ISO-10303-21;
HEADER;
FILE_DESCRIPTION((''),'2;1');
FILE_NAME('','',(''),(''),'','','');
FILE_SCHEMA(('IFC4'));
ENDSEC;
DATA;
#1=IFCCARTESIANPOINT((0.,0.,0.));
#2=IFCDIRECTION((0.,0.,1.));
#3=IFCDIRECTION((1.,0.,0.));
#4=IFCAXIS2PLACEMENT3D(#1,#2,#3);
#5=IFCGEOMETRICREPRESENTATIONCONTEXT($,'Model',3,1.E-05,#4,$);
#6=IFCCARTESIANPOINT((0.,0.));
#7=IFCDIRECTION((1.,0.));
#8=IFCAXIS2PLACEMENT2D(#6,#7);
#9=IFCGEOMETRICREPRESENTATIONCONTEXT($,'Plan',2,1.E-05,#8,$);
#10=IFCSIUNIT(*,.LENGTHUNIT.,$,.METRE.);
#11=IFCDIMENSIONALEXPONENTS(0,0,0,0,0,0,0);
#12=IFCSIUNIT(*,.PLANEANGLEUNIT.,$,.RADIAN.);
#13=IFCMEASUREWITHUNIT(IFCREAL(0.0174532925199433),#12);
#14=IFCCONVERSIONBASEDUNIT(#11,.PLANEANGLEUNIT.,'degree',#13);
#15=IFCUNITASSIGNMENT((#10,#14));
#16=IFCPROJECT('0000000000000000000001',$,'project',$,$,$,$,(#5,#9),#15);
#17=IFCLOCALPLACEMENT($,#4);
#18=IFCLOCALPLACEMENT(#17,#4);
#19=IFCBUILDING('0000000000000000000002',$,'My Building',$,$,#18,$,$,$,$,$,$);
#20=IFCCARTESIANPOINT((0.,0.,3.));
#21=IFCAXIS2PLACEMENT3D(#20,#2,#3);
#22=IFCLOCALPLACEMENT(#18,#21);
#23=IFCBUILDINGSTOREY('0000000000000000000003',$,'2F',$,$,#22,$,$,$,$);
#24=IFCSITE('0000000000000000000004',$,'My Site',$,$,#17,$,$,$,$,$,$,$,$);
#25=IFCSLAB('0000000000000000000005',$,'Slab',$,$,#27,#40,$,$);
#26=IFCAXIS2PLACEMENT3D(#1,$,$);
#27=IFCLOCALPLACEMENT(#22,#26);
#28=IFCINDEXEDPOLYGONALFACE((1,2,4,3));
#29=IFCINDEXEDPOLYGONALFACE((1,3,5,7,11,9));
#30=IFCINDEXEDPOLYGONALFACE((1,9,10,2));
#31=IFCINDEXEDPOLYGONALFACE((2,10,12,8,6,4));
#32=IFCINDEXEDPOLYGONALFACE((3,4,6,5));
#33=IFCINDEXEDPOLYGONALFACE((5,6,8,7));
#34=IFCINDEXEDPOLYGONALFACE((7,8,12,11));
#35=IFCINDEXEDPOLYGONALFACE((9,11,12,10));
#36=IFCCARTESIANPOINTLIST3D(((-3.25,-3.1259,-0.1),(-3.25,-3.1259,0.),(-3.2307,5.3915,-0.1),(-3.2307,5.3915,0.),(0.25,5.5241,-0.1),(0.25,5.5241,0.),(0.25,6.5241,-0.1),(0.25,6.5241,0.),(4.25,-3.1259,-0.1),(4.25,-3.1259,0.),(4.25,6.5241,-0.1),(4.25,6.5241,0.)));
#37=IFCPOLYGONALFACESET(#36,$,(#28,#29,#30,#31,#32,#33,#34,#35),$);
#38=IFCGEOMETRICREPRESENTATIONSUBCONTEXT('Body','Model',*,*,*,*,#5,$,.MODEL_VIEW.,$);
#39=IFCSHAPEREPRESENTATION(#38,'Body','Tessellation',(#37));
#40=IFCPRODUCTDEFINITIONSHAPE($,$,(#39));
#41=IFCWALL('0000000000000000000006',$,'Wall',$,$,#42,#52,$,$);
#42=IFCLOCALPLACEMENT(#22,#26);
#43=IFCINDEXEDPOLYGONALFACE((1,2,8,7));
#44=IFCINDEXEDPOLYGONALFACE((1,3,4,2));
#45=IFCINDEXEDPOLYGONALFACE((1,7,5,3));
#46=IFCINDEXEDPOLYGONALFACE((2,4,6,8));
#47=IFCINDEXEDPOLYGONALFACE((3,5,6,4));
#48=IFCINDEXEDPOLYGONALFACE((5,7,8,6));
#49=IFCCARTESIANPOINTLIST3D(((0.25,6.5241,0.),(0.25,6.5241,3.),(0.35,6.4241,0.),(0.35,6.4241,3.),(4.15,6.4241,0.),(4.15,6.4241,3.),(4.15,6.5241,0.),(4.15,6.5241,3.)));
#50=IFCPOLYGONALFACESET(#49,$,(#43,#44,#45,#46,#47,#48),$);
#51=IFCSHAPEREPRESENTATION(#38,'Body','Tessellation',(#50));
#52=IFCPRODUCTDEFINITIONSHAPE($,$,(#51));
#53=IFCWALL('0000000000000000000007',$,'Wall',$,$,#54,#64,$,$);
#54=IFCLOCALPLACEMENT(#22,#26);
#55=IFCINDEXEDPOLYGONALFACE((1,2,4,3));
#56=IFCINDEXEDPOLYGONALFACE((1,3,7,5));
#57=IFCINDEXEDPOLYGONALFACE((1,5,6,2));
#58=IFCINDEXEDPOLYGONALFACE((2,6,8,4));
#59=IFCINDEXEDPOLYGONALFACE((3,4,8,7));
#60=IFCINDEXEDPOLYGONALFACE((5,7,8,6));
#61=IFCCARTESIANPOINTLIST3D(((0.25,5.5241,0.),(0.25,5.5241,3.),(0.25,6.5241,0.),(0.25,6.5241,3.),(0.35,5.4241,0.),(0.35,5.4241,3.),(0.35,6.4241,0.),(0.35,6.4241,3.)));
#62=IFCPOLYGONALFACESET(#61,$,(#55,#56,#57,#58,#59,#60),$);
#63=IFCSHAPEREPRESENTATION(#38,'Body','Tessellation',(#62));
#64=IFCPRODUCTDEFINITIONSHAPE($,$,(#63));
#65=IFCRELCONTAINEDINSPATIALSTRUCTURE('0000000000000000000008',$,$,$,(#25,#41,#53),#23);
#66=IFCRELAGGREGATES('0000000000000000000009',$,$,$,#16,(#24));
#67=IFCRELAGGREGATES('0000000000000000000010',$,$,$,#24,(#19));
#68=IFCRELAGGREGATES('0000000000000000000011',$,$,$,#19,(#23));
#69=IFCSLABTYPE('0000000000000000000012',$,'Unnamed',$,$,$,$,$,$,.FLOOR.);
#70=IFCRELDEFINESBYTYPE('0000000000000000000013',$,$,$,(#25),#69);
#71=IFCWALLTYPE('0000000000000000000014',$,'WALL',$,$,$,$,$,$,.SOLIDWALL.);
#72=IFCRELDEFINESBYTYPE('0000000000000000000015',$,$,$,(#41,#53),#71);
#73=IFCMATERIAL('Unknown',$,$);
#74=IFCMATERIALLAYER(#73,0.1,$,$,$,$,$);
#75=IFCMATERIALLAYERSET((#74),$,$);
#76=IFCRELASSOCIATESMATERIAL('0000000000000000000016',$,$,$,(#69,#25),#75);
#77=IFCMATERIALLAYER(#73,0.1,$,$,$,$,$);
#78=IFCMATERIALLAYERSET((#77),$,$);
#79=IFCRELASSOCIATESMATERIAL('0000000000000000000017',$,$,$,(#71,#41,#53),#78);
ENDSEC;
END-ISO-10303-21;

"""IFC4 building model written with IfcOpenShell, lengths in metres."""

from ifc_helpers import new_model, entity, si_unit, converted_unit, frame, origin_with_axes, origin_2d_with_axis, place, context, subcontext, project, spatial, line, indexed_curve, outline, extrude, material, layer, layer_set, layer_usage, type_object, element, save


model = new_model("IFC4")

# Units and contexts
model_context = context("Model", 3, precision=1e-05, world=origin_with_axes())
plan_context = context("Plan", 2, precision=1e-05, world=origin_2d_with_axis())
body_context_1 = subcontext(model_context, "Body", "Model", "MODEL_VIEW")
ifc_project = project(units=[si_unit("LENGTHUNIT", "METRE"), converted_unit("PLANEANGLEUNIT", "degree", entity("IfcReal", 0.0174532925199433), si_unit("PLANEANGLEUNIT", "RADIAN"), dimensions=[0, 0, 0, 0, 0, 0, 0])], contexts=[model_context, plan_context])

# Site, building, storey
site_placement = place(None, origin_with_axes())
site = spatial("IfcSite", under=ifc_project, at=site_placement, Name="My Site")
building_placement = place(site_placement, origin_with_axes())
building = spatial("IfcBuilding", under=site, at=building_placement, Name="My Building")
storey_placement = place(building_placement, frame((0.0, 0.0, 3.0), z_axis=(0.0, 0.0, 1.0), x_axis=(1.0, 0.0, 0.0)))
storey = spatial("IfcBuildingStorey", under=building, at=storey_placement, Name="2F")

# Slab
ifc_material = material(Name="Unknown")
ifc_layer_1 = layer(ifc_material, 0.1)
ifc_layer_set_1 = layer_set([ifc_layer_1])
ifc_layer_usage_1 = layer_usage(ifc_layer_set_1, "AXIS3", "POSITIVE", -0.1)
slab_type = type_object("IfcSlabType", Name="Unnamed", PredefinedType="FLOOR", material=ifc_layer_set_1)
slab_placement = place(storey_placement, frame((4.25, 6.5241, 0.0), z_axis=(0.0, 0.0, 1.0), x_axis=(1.0, 0.0, 0.0)))
element("IfcSlab", 1, at=slab_placement, inside=storey, type_object=slab_type, material=ifc_layer_usage_1, Name="Slab", context=body_context_1, shape_type="SweptSolid", body=[
    extrude(outline(indexed_curve([(0.0, 0.0), (-4.0, 0.0), (-4.0, -1.0), (-7.4807, -1.1326), (-7.5, -9.65), (0.0, -9.65), (0.0, 0.0)])), frame((0.0, 0.0, -0.1), z_axis=(0.0, 0.0, 1.0), x_axis=(1.0, 0.0, 0.0)), (0.0, 0.0, 1.0), 0.1),
])

# Walls
ifc_layer_2 = layer(ifc_material, 0.1)
ifc_layer_set_2 = layer_set([ifc_layer_2])
ifc_layer_usage_2 = layer_usage(ifc_layer_set_2, "AXIS2", "POSITIVE", 0.0)
wall_type = type_object("IfcWallType", Name="WALL", PredefinedType="SOLIDWALL", material=ifc_layer_set_2)
wall_1_placement = place(storey_placement, frame((4.15, 6.5241, 0.0), z_axis=(0.0, 0.0, 1.0), x_axis=(-1.0, 0.0, 0.0)))
element("IfcWall", 2, at=wall_1_placement, inside=storey, type_object=wall_type, material=ifc_layer_usage_2, Name="Wall", context=body_context_1, shape_type="SweptSolid", body=[
    extrude(outline(indexed_curve([(0.0, 0.0), (0.0, 0.1), (3.8, 0.1), (3.9, 0.0)], segments=[line(1, 2, 3, 4, 1)])), origin_with_axes(), (0.0, 0.0, 1.0), 3.0),
])
ifc_layer_usage_3 = layer_usage(ifc_layer_set_2, "AXIS2", "POSITIVE", 0.0)
wall_2_placement = place(storey_placement, frame((0.25, 6.5241, 0.0), z_axis=(0.0, 0.0, 1.0), x_axis=(0.0, -1.0, 0.0)))
element("IfcWall", 3, at=wall_2_placement, inside=storey, type_object=wall_type, material=ifc_layer_usage_3, Name="Wall", context=body_context_1, shape_type="SweptSolid", body=[
    extrude(outline(indexed_curve([(0.0, 0.0), (0.1, 0.1), (1.1, 0.1), (1.0, 0.0)], segments=[line(1, 2, 3, 4, 1)])), origin_with_axes(), (0.0, 0.0, 1.0), 3.0),
])

save(model, "model.ifc")
